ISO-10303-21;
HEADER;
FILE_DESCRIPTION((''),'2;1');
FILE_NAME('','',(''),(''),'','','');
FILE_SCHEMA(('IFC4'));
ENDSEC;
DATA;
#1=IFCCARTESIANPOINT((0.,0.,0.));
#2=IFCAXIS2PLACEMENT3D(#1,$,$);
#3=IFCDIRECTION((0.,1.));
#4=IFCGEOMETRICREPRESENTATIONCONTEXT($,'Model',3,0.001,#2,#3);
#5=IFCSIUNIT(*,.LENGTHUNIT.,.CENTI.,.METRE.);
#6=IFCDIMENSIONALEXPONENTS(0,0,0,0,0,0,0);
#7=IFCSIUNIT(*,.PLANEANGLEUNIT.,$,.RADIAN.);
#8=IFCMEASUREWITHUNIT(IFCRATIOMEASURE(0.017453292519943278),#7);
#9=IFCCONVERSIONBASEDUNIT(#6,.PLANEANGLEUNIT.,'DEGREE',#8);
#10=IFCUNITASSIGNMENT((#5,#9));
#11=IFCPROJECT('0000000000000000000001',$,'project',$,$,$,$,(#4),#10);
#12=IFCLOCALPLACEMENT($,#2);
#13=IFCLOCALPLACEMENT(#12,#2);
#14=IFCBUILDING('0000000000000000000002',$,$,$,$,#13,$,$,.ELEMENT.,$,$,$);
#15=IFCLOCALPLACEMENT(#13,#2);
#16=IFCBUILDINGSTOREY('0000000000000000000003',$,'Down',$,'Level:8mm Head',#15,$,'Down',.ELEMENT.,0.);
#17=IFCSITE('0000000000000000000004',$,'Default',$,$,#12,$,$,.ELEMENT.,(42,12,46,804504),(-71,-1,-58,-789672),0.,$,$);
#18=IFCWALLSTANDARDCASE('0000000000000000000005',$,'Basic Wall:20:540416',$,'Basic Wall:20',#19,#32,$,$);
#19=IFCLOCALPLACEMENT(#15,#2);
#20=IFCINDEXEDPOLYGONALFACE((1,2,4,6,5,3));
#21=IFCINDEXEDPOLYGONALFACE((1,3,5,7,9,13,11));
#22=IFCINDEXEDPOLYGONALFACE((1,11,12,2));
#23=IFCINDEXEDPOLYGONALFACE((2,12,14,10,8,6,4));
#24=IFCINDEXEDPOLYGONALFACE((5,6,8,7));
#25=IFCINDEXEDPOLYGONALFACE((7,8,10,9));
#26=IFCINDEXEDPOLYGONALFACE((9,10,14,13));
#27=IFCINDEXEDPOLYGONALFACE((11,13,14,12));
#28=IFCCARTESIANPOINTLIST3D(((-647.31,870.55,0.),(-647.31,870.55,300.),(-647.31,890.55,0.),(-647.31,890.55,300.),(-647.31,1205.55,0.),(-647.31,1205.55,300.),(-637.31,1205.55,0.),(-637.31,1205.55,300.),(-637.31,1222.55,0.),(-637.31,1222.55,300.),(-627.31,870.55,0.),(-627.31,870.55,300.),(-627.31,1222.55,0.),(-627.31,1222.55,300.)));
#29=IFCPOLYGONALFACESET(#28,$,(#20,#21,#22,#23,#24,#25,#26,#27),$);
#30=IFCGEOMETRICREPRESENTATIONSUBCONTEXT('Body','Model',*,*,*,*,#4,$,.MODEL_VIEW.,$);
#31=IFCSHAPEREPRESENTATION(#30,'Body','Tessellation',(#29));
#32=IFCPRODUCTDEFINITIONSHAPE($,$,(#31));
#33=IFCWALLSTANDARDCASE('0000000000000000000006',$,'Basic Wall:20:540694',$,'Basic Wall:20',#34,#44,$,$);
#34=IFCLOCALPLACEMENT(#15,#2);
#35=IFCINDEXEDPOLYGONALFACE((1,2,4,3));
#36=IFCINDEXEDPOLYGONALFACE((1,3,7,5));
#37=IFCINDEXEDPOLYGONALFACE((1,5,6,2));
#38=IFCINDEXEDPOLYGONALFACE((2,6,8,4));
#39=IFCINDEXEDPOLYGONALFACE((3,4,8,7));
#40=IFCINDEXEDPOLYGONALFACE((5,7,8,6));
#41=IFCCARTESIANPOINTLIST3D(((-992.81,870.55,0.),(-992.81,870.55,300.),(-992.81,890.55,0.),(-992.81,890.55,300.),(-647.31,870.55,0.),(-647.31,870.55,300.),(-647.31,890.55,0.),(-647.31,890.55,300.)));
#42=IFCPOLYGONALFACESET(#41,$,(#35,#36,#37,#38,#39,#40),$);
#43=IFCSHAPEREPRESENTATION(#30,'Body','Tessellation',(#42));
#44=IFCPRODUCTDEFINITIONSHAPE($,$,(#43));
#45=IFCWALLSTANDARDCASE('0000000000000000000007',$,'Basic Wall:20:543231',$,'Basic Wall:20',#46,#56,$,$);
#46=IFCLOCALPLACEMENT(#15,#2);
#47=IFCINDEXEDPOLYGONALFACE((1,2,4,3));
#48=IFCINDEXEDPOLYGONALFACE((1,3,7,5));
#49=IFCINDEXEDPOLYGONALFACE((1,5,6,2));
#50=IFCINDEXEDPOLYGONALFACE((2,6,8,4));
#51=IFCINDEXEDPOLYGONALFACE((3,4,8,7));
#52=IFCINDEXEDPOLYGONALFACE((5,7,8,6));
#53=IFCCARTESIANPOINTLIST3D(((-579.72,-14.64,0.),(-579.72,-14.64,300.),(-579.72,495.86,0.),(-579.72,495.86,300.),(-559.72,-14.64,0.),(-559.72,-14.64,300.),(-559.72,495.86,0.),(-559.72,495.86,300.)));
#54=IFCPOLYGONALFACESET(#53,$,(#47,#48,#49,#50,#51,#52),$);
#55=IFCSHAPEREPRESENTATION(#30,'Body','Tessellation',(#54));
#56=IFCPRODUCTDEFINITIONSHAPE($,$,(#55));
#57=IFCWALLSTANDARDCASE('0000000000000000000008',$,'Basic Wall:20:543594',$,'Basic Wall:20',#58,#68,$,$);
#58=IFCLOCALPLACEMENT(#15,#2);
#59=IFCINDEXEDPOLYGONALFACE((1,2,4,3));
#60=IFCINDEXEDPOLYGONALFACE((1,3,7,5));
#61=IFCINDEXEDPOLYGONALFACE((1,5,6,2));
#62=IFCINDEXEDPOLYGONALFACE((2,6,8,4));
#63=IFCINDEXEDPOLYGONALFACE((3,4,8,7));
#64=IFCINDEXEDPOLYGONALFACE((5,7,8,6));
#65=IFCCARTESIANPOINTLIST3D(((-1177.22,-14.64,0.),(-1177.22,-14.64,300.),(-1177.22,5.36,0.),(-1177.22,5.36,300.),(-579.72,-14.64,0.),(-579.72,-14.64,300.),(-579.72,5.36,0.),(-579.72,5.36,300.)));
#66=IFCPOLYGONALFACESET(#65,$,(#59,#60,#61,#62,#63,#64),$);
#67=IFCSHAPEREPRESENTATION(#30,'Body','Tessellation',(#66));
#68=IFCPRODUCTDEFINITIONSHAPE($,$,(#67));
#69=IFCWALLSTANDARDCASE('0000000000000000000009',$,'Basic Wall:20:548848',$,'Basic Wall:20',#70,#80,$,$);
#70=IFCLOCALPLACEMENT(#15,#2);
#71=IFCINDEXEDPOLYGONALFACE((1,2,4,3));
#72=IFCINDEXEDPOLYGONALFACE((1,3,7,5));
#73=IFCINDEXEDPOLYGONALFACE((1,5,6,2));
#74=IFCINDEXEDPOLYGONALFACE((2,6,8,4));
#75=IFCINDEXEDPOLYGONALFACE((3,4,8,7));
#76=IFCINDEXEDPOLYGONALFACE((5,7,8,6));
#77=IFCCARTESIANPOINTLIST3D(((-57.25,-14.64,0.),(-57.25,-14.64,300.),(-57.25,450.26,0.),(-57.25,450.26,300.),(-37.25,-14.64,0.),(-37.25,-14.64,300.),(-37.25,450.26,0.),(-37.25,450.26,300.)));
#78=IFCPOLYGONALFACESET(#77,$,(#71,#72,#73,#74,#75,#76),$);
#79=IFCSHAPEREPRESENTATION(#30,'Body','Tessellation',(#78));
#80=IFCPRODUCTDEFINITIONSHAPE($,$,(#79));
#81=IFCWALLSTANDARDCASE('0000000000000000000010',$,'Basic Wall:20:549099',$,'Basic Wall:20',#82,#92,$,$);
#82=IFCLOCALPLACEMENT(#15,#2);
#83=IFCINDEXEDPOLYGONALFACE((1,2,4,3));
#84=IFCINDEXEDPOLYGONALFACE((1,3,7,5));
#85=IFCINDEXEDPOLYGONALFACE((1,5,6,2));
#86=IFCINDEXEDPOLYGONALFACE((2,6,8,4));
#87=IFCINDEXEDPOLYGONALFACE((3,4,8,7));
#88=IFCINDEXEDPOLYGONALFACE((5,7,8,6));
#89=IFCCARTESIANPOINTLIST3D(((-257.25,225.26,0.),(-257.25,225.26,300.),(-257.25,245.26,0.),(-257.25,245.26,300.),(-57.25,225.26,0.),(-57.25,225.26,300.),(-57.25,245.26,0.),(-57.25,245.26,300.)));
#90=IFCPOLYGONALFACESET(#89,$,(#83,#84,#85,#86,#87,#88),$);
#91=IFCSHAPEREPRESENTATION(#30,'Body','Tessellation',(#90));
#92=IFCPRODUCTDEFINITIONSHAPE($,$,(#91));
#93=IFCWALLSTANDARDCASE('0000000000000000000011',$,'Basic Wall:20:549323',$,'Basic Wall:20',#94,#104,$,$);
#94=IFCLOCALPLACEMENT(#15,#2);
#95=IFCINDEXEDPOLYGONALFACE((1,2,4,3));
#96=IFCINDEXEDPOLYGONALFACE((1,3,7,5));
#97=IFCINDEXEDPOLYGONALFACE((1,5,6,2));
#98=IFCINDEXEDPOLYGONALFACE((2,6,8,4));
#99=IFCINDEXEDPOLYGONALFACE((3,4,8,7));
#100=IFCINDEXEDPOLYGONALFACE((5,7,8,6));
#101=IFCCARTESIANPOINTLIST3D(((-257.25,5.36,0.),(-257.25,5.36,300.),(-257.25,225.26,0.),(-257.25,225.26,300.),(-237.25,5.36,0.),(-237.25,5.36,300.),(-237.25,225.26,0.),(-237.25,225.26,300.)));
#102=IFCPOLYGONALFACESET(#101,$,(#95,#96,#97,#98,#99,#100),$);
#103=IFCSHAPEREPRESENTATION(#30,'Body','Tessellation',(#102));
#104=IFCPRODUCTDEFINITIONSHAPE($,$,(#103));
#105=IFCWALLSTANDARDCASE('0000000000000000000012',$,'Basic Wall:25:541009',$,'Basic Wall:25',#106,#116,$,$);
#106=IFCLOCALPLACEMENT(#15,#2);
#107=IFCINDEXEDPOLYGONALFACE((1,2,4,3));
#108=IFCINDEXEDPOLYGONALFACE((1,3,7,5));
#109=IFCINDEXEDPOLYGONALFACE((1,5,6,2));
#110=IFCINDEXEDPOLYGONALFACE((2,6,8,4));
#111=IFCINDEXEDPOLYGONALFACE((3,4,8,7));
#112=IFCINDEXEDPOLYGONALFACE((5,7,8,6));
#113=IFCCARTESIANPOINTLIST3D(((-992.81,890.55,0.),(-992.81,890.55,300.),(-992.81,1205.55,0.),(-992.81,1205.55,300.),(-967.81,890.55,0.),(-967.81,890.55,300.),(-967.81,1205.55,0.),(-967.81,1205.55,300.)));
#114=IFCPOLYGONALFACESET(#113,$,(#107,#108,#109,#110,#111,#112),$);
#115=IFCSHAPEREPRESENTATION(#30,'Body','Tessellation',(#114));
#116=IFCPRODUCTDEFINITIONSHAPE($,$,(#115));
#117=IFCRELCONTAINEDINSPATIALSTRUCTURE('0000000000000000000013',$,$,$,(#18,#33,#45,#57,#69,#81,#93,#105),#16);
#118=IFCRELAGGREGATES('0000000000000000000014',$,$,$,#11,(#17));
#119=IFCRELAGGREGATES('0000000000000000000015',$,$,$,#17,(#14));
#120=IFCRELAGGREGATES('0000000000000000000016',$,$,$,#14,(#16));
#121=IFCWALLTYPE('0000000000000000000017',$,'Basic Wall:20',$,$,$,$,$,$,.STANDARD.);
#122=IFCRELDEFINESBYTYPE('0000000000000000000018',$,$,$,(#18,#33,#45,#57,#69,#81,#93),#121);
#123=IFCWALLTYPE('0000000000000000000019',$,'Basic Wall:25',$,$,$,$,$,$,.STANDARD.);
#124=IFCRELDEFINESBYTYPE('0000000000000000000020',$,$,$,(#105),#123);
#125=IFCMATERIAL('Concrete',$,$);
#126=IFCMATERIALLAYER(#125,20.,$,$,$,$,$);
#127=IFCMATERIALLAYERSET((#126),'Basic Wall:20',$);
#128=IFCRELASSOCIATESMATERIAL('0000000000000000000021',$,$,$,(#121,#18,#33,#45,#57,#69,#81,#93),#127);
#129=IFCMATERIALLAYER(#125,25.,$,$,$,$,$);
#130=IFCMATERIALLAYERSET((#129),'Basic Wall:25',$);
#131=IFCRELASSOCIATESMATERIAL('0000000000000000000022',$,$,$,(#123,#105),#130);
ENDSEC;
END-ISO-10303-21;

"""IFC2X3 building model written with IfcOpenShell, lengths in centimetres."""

from ifc_helpers import new_model, entity, si_unit, converted_unit, direction, frame, frame_2d, origin, place, context, subcontext, project, spatial, polyline, rectangle, outline, extrude, material, layer, layer_set, layer_usage, type_object, element, save


model = new_model("IFC2X3")

# Units and contexts
model_context = context("Model", 3, precision=0.001, world=origin(), true_north=direction((0.0, 1.0)))
body_context = subcontext(model_context, "Body", "Model", "MODEL_VIEW")
ifc_project = project(units=[si_unit("LENGTHUNIT", "METRE", prefix="CENTI"), converted_unit("PLANEANGLEUNIT", "DEGREE", entity("IfcRatioMeasure", 0.017453292519943278), si_unit("PLANEANGLEUNIT", "RADIAN"), dimensions=[0, 0, 0, 0, 0, 0, 0])], contexts=[model_context])

# Site, building, storey
site_placement = place(None, origin())
site = spatial("IfcSite", under=ifc_project, at=site_placement, Name="Default", CompositionType="ELEMENT", RefLatitude=(42, 12, 46, 804504), RefLongitude=(-71, -1, -58, -789672), RefElevation=0.0)
building_placement = place(site_placement, origin())
building = spatial("IfcBuilding", under=site, at=building_placement, CompositionType="ELEMENT")
storey_placement = place(building_placement, origin())
storey = spatial("IfcBuildingStorey", under=building, at=storey_placement, Name="Down", ObjectType="Level:8mm Head", LongName="Down", CompositionType="ELEMENT", Elevation=0.0)

# Shared definitions
ifc_material = material(Name="Concrete")

# Walls
ifc_layer_1 = layer(ifc_material, 20.0)
ifc_layer_set_1 = layer_set([ifc_layer_1], Name="Basic Wall:20")
ifc_layer_usage_1 = layer_usage(ifc_layer_set_1, "AXIS2", "NEGATIVE", 10.0)
wall_type_1 = type_object("IfcWallType", Name="Basic Wall:20", PredefinedType="STANDARD", material=ifc_layer_set_1)
wall_1_placement = place(storey_placement, frame((-637.31, 1222.55, 0.0), z_axis=(0.0, 0.0, 1.0), x_axis=(0.0, -1.0, 0.0)))
element("IfcWallStandardCase", 1, at=wall_1_placement, inside=storey, type_object=wall_type_1, material=ifc_layer_usage_1, Name="Basic Wall:20:540416", ObjectType="Basic Wall:20", context=body_context, shape_type="SweptSolid", body=[
    extrude(outline(polyline([(352.0, -10.0), (352.0, 10.0), (0.0, 10.0), (0.0, 0.0), (17.0, 0.0), (17.0, -10.0), (332.0, -10.0), (352.0, -10.0)])), origin(), (0.0, 0.0, 1.0), 300.0),
])
ifc_layer_usage_2 = layer_usage(ifc_layer_set_1, "AXIS2", "NEGATIVE", 10.0)
wall_2_placement = place(storey_placement, frame((-647.31, 880.55, 0.0), z_axis=(0.0, 0.0, 1.0), x_axis=(-1.0, 0.0, 0.0)))
element("IfcWallStandardCase", 2, at=wall_2_placement, inside=storey, type_object=wall_type_1, material=ifc_layer_usage_2, Name="Basic Wall:20:540694", ObjectType="Basic Wall:20", context=body_context, shape_type="SweptSolid", body=[
    extrude(rectangle(XDim=345.5, YDim=20.0, at=frame_2d((172.75, 0.0), x_axis=(-1.0, 0.0))), origin(), (0.0, 0.0, 1.0), 300.0),
])
ifc_layer_usage_3 = layer_usage(ifc_layer_set_1, "AXIS2", "NEGATIVE", 10.0)
wall_3_placement = place(storey_placement, frame((-569.72, 495.86, 0.0), z_axis=(0.0, 0.0, 1.0), x_axis=(0.0, -1.0, 0.0)))
element("IfcWallStandardCase", 3, at=wall_3_placement, inside=storey, type_object=wall_type_1, material=ifc_layer_usage_3, Name="Basic Wall:20:543231", ObjectType="Basic Wall:20", context=body_context, shape_type="SweptSolid", body=[
    extrude(rectangle(XDim=510.5, YDim=20.0, at=frame_2d((255.25, 0.0), x_axis=(-1.0, 0.0))), origin(), (0.0, 0.0, 1.0), 300.0),
])
ifc_layer_usage_4 = layer_usage(ifc_layer_set_1, "AXIS2", "NEGATIVE", 10.0)
wall_4_placement = place(storey_placement, frame((-579.72, -4.64, 0.0), z_axis=(0.0, 0.0, 1.0), x_axis=(-1.0, 0.0, 0.0)))
element("IfcWallStandardCase", 4, at=wall_4_placement, inside=storey, type_object=wall_type_1, material=ifc_layer_usage_4, Name="Basic Wall:20:543594", ObjectType="Basic Wall:20", context=body_context, shape_type="SweptSolid", body=[
    extrude(rectangle(XDim=597.5, YDim=20.0, at=frame_2d((298.75, 0.0), x_axis=(-1.0, 0.0))), origin(), (0.0, 0.0, 1.0), 300.0),
])
ifc_layer_usage_5 = layer_usage(ifc_layer_set_1, "AXIS2", "POSITIVE", -10.0)
wall_5_placement = place(storey_placement, frame((-47.25, 450.26, 0.0), z_axis=(0.0, 0.0, 1.0), x_axis=(0.0, -1.0, 0.0)))
element("IfcWallStandardCase", 5, at=wall_5_placement, inside=storey, type_object=wall_type_1, material=ifc_layer_usage_5, Name="Basic Wall:20:548848", ObjectType="Basic Wall:20", context=body_context, shape_type="SweptSolid", body=[
    extrude(rectangle(XDim=464.9, YDim=20.0, at=frame_2d((232.45, 0.0), x_axis=(-1.0, 0.0))), origin(), (0.0, 0.0, 1.0), 300.0),
])
ifc_layer_usage_6 = layer_usage(ifc_layer_set_1, "AXIS2", "POSITIVE", -10.0)
wall_6_placement = place(storey_placement, frame((-57.25, 235.26, 0.0), z_axis=(0.0, 0.0, 1.0), x_axis=(-1.0, 0.0, 0.0)))
element("IfcWallStandardCase", 6, at=wall_6_placement, inside=storey, type_object=wall_type_1, material=ifc_layer_usage_6, Name="Basic Wall:20:549099", ObjectType="Basic Wall:20", context=body_context, shape_type="SweptSolid", body=[
    extrude(rectangle(XDim=200.0, YDim=20.0, at=frame_2d((100.0, 0.0), x_axis=(-1.0, 0.0))), origin(), (0.0, 0.0, 1.0), 300.0),
])
ifc_layer_usage_7 = layer_usage(ifc_layer_set_1, "AXIS2", "POSITIVE", -10.0)
wall_7_placement = place(storey_placement, frame((-247.25, 225.26, 0.0), z_axis=(0.0, 0.0, 1.0), x_axis=(0.0, -1.0, 0.0)))
element("IfcWallStandardCase", 7, at=wall_7_placement, inside=storey, type_object=wall_type_1, material=ifc_layer_usage_7, Name="Basic Wall:20:549323", ObjectType="Basic Wall:20", context=body_context, shape_type="SweptSolid", body=[
    extrude(rectangle(XDim=219.9, YDim=20.0, at=frame_2d((109.95, 0.0), x_axis=(-1.0, 0.0))), origin(), (0.0, 0.0, 1.0), 300.0),
])
ifc_layer_2 = layer(ifc_material, 25.0)
ifc_layer_set_2 = layer_set([ifc_layer_2], Name="Basic Wall:25")
ifc_layer_usage_8 = layer_usage(ifc_layer_set_2, "AXIS2", "POSITIVE", -12.5)
wall_type_2 = type_object("IfcWallType", Name="Basic Wall:25", PredefinedType="STANDARD", material=ifc_layer_set_2)
wall_8_placement = place(storey_placement, frame((-980.31, 1205.55, 0.0), z_axis=(0.0, 0.0, 1.0), x_axis=(0.0, -1.0, 0.0)))
element("IfcWallStandardCase", 8, at=wall_8_placement, inside=storey, type_object=wall_type_2, material=ifc_layer_usage_8, Name="Basic Wall:25:541009", ObjectType="Basic Wall:25", context=body_context, shape_type="SweptSolid", body=[
    extrude(rectangle(XDim=315.0, YDim=25.0, at=frame_2d((157.5, 0.0), x_axis=(-1.0, 0.0))), origin(), (0.0, 0.0, 1.0), 300.0),
])

save(model, "model.ifc")
